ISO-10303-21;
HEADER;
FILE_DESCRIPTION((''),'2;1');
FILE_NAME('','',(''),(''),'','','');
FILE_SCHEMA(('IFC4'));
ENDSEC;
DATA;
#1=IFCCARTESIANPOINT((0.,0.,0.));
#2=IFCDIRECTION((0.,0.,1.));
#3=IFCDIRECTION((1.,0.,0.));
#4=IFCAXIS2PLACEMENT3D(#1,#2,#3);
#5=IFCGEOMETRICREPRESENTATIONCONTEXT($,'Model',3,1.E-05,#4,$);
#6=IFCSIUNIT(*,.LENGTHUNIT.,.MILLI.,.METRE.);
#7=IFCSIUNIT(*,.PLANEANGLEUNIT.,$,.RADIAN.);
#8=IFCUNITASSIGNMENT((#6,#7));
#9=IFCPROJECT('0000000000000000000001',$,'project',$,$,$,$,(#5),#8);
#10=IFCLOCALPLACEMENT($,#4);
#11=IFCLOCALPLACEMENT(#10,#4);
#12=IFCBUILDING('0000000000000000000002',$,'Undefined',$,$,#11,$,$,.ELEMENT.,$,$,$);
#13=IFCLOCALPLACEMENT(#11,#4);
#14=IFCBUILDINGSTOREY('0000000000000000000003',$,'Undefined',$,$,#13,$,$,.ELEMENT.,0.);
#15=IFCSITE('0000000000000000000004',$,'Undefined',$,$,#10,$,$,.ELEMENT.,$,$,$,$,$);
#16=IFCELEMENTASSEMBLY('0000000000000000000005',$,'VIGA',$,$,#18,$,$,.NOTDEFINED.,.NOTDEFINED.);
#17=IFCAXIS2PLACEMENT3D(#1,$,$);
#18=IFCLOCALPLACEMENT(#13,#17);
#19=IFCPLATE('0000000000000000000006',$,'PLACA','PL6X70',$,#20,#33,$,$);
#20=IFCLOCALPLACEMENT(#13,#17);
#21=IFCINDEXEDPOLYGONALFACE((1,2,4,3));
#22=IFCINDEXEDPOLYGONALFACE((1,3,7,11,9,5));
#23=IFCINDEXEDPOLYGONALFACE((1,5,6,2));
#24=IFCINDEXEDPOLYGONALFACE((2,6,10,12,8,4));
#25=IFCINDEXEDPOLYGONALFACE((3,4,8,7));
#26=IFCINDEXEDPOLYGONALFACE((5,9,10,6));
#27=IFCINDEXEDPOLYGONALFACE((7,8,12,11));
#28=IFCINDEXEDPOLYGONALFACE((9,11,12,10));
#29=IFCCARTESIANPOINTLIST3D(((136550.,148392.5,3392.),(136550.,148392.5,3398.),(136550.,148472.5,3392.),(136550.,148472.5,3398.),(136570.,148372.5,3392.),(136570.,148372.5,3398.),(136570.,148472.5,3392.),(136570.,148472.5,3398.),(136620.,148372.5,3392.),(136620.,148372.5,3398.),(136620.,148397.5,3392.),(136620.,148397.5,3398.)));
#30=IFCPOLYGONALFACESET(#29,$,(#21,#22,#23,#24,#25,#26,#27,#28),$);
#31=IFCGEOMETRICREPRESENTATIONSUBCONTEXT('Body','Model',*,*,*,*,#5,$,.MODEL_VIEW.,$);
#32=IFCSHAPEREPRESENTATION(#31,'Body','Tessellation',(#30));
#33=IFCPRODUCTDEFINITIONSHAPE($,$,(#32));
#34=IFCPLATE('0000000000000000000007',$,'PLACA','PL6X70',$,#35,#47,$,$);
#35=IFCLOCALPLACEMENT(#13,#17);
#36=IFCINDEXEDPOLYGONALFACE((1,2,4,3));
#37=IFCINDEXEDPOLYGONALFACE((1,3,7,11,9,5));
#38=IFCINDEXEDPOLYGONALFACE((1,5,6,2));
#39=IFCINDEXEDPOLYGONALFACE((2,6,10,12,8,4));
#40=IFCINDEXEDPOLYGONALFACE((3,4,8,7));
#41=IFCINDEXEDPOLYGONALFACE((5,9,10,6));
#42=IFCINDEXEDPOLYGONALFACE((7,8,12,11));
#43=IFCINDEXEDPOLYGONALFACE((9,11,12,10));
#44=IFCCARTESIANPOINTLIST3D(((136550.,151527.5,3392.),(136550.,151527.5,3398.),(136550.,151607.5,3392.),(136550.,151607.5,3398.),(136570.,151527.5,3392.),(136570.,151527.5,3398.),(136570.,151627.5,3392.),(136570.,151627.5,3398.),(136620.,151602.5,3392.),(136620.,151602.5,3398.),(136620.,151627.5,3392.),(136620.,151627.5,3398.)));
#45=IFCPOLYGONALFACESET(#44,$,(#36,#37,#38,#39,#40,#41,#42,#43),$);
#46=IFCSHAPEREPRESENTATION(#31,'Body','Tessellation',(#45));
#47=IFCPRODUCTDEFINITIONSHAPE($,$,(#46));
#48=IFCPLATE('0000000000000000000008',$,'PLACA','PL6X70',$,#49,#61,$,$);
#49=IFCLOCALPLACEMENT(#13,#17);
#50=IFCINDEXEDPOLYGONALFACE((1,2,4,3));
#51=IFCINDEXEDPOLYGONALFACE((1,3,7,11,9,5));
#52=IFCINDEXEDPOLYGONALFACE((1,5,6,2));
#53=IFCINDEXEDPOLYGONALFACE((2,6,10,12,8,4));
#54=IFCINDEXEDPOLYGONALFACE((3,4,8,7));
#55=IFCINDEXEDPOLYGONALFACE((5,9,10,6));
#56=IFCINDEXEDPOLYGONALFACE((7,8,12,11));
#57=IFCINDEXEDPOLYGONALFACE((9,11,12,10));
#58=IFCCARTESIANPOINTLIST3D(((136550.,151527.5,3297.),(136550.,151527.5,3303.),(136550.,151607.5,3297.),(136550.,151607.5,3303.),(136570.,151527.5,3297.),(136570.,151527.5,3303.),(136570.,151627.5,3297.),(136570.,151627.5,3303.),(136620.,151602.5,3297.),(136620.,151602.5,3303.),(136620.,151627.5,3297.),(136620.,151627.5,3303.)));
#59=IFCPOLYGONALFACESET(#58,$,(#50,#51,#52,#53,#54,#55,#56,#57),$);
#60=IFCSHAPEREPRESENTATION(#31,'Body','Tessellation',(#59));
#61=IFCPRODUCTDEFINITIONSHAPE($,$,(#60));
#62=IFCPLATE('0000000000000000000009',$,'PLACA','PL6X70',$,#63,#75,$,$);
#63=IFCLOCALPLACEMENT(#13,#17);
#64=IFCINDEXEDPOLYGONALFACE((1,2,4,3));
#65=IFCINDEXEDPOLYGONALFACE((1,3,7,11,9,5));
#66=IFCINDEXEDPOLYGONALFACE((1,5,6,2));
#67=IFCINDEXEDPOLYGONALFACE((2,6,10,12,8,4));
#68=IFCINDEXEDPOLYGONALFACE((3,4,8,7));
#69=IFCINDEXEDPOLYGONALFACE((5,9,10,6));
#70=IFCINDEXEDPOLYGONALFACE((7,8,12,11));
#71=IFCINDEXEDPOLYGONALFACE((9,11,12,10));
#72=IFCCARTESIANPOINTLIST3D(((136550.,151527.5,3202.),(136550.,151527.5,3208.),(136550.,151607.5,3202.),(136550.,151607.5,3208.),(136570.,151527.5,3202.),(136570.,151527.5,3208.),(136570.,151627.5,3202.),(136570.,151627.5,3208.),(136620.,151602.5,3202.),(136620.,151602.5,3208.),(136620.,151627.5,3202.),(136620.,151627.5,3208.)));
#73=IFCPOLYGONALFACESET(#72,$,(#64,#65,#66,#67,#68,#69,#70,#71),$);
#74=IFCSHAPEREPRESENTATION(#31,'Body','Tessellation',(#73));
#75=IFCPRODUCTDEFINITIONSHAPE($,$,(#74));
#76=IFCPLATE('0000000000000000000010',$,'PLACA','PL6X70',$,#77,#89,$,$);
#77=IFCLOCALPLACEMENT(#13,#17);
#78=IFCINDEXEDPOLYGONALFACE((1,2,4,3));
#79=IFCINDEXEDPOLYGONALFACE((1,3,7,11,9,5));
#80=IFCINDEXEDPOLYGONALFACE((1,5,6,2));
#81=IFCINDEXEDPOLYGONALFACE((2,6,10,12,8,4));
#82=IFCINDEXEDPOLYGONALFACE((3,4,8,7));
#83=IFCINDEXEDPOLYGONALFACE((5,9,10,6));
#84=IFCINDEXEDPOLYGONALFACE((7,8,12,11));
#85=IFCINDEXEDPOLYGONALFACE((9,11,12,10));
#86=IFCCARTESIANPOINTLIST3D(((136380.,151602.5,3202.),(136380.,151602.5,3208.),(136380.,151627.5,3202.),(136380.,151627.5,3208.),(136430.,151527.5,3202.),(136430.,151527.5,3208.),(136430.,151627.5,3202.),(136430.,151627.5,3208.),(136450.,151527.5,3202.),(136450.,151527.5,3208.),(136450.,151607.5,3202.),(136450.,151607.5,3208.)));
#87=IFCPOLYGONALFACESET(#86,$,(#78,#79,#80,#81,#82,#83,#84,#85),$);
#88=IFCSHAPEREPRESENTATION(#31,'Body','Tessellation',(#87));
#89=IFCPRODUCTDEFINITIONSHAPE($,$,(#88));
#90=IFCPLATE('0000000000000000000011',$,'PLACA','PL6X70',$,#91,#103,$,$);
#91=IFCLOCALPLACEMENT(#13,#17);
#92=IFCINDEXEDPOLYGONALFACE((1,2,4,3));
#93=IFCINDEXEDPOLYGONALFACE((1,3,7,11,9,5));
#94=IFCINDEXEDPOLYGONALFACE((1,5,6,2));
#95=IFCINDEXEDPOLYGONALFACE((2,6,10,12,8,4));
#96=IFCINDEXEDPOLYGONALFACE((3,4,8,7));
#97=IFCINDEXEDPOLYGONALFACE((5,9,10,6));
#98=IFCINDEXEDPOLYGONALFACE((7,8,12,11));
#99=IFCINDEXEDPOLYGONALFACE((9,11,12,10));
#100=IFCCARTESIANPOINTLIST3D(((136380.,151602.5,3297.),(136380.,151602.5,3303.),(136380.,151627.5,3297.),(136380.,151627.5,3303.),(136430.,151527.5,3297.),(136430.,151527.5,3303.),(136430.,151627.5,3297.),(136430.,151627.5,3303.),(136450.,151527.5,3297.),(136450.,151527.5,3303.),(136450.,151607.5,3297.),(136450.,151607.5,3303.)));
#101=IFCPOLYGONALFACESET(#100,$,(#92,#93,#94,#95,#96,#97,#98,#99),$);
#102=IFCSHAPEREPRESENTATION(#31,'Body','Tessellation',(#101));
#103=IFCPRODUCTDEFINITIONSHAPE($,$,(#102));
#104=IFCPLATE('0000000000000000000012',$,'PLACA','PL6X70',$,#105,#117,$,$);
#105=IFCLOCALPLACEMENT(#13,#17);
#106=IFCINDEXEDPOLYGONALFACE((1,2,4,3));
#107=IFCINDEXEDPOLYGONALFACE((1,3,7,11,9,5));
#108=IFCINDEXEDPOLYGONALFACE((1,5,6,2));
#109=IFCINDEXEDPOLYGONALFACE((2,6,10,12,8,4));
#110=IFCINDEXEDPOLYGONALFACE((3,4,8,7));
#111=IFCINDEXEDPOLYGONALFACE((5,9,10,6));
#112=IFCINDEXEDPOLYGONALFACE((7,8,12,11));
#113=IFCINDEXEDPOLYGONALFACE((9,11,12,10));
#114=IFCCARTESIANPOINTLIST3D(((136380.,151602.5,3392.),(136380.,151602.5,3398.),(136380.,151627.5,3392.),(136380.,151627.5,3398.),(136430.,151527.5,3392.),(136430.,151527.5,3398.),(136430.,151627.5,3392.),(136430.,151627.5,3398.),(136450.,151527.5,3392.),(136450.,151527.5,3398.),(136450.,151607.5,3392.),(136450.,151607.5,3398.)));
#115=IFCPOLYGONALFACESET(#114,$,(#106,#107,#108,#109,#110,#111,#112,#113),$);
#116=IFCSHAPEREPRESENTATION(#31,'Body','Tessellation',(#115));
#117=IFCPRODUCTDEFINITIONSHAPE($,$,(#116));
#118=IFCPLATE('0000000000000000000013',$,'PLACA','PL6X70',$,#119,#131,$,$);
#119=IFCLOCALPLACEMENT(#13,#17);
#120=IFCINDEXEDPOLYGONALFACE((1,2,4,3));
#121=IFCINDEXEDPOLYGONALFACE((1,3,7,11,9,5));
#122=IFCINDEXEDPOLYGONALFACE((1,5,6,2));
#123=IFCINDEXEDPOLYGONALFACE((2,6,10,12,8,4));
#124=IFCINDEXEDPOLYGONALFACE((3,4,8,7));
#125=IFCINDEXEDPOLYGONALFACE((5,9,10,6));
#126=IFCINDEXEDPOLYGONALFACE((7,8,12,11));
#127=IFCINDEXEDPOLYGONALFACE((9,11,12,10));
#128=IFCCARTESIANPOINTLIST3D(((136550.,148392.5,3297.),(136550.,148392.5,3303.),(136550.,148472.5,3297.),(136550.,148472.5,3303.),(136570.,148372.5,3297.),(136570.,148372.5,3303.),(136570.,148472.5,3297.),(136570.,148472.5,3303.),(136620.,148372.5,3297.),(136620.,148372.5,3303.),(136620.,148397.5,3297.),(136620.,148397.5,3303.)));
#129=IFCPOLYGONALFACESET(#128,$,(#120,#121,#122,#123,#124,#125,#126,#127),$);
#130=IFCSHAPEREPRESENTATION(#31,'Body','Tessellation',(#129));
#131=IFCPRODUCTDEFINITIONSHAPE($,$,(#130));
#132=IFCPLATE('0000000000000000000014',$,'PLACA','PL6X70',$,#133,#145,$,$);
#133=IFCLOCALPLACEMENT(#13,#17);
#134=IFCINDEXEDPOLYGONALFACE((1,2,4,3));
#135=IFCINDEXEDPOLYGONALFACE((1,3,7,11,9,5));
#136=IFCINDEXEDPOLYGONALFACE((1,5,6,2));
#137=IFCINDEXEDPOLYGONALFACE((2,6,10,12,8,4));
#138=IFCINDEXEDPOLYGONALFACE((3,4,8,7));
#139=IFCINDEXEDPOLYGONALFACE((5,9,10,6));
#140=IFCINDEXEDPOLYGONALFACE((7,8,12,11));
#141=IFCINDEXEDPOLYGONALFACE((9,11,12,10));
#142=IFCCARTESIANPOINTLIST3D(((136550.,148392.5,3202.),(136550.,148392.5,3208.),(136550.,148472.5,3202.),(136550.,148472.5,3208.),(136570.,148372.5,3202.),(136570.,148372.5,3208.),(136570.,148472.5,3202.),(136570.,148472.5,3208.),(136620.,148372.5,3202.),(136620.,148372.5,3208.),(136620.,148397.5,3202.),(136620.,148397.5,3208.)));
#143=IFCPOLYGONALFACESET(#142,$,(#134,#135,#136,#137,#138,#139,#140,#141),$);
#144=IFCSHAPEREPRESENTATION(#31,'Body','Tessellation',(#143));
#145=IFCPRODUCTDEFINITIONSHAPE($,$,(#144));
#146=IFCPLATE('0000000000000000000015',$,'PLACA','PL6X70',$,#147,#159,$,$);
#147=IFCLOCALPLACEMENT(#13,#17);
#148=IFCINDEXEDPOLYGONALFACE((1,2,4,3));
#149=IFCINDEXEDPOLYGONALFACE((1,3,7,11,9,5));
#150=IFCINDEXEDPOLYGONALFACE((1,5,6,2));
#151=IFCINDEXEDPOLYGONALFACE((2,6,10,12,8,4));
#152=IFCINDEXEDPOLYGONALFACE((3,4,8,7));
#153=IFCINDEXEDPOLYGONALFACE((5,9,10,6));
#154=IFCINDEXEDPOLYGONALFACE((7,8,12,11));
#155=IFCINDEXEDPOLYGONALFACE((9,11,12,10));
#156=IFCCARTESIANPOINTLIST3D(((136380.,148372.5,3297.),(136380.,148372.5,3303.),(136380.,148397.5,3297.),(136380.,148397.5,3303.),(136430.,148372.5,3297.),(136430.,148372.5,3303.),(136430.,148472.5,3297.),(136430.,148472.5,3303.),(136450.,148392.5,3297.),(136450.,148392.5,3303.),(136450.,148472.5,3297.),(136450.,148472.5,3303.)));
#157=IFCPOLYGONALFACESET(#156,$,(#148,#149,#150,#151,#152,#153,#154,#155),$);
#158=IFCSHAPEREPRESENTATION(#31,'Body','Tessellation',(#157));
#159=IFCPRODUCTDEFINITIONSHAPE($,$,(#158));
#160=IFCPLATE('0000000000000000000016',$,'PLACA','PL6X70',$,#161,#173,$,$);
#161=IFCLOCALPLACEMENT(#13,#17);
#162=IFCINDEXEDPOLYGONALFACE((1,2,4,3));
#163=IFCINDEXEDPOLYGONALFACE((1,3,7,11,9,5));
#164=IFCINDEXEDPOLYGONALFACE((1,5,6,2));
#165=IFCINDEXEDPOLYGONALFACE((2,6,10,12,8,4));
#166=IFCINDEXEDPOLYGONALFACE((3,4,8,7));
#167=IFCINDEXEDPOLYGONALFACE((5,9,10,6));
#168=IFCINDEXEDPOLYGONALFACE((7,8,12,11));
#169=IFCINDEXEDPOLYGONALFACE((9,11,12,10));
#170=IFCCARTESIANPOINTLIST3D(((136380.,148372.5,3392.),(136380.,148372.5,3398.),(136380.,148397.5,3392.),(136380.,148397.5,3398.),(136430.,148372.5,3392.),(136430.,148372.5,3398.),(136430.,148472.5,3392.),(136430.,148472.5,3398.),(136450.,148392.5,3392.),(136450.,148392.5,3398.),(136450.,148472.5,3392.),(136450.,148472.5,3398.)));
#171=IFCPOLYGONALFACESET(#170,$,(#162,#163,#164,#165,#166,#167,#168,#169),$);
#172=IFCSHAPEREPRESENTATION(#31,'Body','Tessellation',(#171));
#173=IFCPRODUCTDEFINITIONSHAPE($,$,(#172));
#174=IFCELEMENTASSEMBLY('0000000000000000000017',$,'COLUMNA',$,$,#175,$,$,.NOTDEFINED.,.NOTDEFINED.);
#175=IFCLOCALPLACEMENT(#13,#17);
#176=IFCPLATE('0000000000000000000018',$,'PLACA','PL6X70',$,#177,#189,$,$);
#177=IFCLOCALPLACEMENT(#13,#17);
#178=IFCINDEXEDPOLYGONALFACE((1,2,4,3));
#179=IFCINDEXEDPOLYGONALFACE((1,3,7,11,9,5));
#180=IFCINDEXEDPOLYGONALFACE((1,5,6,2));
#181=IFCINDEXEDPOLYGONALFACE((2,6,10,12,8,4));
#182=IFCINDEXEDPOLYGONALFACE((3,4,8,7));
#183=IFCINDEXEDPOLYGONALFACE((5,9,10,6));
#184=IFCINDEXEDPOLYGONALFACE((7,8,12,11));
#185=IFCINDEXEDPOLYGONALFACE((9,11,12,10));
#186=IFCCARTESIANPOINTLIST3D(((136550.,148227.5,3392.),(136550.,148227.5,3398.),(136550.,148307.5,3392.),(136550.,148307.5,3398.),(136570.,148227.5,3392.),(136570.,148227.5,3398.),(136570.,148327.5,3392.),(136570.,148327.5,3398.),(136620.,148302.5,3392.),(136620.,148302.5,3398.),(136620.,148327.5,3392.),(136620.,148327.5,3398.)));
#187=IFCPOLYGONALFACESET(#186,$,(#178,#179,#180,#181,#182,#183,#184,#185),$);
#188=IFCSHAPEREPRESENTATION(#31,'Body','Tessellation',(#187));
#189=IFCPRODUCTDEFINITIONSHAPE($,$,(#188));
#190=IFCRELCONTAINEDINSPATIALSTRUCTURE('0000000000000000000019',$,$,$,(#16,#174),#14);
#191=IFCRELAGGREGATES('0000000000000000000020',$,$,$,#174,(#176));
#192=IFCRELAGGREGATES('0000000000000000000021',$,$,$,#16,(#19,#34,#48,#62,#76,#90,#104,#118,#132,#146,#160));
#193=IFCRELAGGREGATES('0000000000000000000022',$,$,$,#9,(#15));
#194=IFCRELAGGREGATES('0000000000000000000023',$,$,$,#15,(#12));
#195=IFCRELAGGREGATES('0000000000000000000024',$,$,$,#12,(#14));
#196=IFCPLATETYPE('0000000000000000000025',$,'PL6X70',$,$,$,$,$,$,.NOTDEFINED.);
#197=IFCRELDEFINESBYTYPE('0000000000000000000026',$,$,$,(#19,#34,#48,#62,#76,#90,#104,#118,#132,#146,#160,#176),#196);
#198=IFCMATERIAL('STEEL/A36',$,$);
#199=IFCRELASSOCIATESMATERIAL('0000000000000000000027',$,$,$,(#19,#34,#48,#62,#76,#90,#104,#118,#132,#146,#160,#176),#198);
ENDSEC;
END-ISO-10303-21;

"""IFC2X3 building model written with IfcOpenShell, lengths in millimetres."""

from ifc_helpers import new_model, si_unit, frame, origin_with_axes, place, context, subcontext, project, spatial, polyline, outline, extrude, material, type_object, element, aggregate, save


model = new_model("IFC2X3")

# Units and contexts
model_context = context("Model", 3, precision=1e-05, world=origin_with_axes())
body_context = subcontext(model_context, "Body", "Model", "MODEL_VIEW")
ifc_project = project(units=[si_unit("LENGTHUNIT", "METRE", prefix="MILLI"), si_unit("PLANEANGLEUNIT", "RADIAN")], contexts=[model_context])

# Site, building, storey
site_placement = place(None, origin_with_axes())
site = spatial("IfcSite", under=ifc_project, at=site_placement, Name="Undefined", CompositionType="ELEMENT")
building_placement = place(site_placement, origin_with_axes())
building = spatial("IfcBuilding", under=site, at=building_placement, Name="Undefined", CompositionType="ELEMENT")
storey_placement = place(building_placement, origin_with_axes())
storey = spatial("IfcBuildingStorey", under=building, at=storey_placement, Name="Undefined", CompositionType="ELEMENT", Elevation=0.0)

# Element assembly
assembly_1_placement = place(storey_placement, origin_with_axes())
assembly_1 = element("IfcElementAssembly", 1, at=assembly_1_placement, inside=storey, Name="VIGA", AssemblyPlace="NOTDEFINED", PredefinedType="NOTDEFINED")
ifc_material_1 = material(Name="STEEL/A36")

# Plates
plate_type_1 = type_object("IfcPlateType", Name="PL6X70", PredefinedType="NOTDEFINED")
plate_1_placement = place(assembly_1_placement, frame((136620.0, 148372.5, 3395.0), z_axis=(0.0, 0.0, 1.0), x_axis=(0.0, 1.0, 0.0)))
plate_1 = element("IfcPlate", 2, at=plate_1_placement, type_object=plate_type_1, material=ifc_material_1, Name="PLACA", Description="PL6X70", context=body_context, shape_type="SweptSolid", body=[
    extrude(outline(polyline([(0.0, 0.0), (25.0, 0.0), (100.0, 50.0), (100.0, 70.0), (20.0, 70.0), (0.0, 50.0), (0.0, 0.0)])), frame((0.0, 0.0, -3.0), z_axis=(0.0, 0.0, 1.0), x_axis=(1.0, 0.0, 0.0)), (0.0, 0.0, 1.0), 6.0),
])
plate_2_placement = place(assembly_1_placement, frame((136620.0, 151627.5, 3395.0), z_axis=(0.0, 0.0, -1.0), x_axis=(0.0, -1.0, 0.0)))
plate_2 = element("IfcPlate", 3, at=plate_2_placement, type_object=plate_type_1, material=ifc_material_1, Name="PLACA", Description="PL6X70", context=body_context, shape_type="SweptSolid", body=[
    extrude(outline(polyline([(0.0, 0.0), (25.0, 0.0), (100.0, 50.0), (100.0, 70.0), (20.0, 70.0), (0.0, 50.0), (0.0, 0.0)])), frame((0.0, 0.0, -3.0), z_axis=(0.0, 0.0, 1.0), x_axis=(1.0, 0.0, 0.0)), (0.0, 0.0, 1.0), 6.0),
])
plate_3_placement = place(assembly_1_placement, frame((136620.0, 151627.5, 3300.0), z_axis=(0.0, 0.0, -1.0), x_axis=(0.0, -1.0, 0.0)))
plate_3 = element("IfcPlate", 4, at=plate_3_placement, type_object=plate_type_1, material=ifc_material_1, Name="PLACA", Description="PL6X70", context=body_context, shape_type="SweptSolid", body=[
    extrude(outline(polyline([(0.0, 0.0), (25.0, 0.0), (100.0, 50.0), (100.0, 70.0), (20.0, 70.0), (0.0, 50.0), (0.0, 0.0)])), frame((0.0, 0.0, -3.0), z_axis=(0.0, 0.0, 1.0), x_axis=(1.0, 0.0, 0.0)), (0.0, 0.0, 1.0), 6.0),
])
plate_4_placement = place(assembly_1_placement, frame((136620.0, 151627.5, 3205.0), z_axis=(0.0, 0.0, -1.0), x_axis=(0.0, -1.0, 0.0)))
plate_4 = element("IfcPlate", 5, at=plate_4_placement, type_object=plate_type_1, material=ifc_material_1, Name="PLACA", Description="PL6X70", context=body_context, shape_type="SweptSolid", body=[
    extrude(outline(polyline([(0.0, 0.0), (25.0, 0.0), (100.0, 50.0), (100.0, 70.0), (20.0, 70.0), (0.0, 50.0), (0.0, 0.0)])), frame((0.0, 0.0, -3.0), z_axis=(0.0, 0.0, 1.0), x_axis=(1.0, 0.0, 0.0)), (0.0, 0.0, 1.0), 6.0),
])
plate_5_placement = place(assembly_1_placement, frame((136380.0, 151627.5, 3205.0), z_axis=(0.0, 0.0, 1.0), x_axis=(0.0, -1.0, 0.0)))
plate_5 = element("IfcPlate", 6, at=plate_5_placement, type_object=plate_type_1, material=ifc_material_1, Name="PLACA", Description="PL6X70", context=body_context, shape_type="SweptSolid", body=[
    extrude(outline(polyline([(0.0, 0.0), (25.0, 0.0), (100.0, 50.0), (100.0, 70.0), (20.0, 70.0), (0.0, 50.0), (0.0, 0.0)])), frame((0.0, 0.0, -3.0), z_axis=(0.0, 0.0, 1.0), x_axis=(1.0, 0.0, 0.0)), (0.0, 0.0, 1.0), 6.0),
])
plate_6_placement = place(assembly_1_placement, frame((136380.0, 151627.5, 3300.0), z_axis=(0.0, 0.0, 1.0), x_axis=(0.0, -1.0, 0.0)))
plate_6 = element("IfcPlate", 7, at=plate_6_placement, type_object=plate_type_1, material=ifc_material_1, Name="PLACA", Description="PL6X70", context=body_context, shape_type="SweptSolid", body=[
    extrude(outline(polyline([(0.0, 0.0), (25.0, 0.0), (100.0, 50.0), (100.0, 70.0), (20.0, 70.0), (0.0, 50.0), (0.0, 0.0)])), frame((0.0, 0.0, -3.0), z_axis=(0.0, 0.0, 1.0), x_axis=(1.0, 0.0, 0.0)), (0.0, 0.0, 1.0), 6.0),
])
plate_7_placement = place(assembly_1_placement, frame((136380.0, 151627.5, 3395.0), z_axis=(0.0, 0.0, 1.0), x_axis=(0.0, -1.0, 0.0)))
plate_7 = element("IfcPlate", 8, at=plate_7_placement, type_object=plate_type_1, material=ifc_material_1, Name="PLACA", Description="PL6X70", context=body_context, shape_type="SweptSolid", body=[
    extrude(outline(polyline([(0.0, 0.0), (25.0, 0.0), (100.0, 50.0), (100.0, 70.0), (20.0, 70.0), (0.0, 50.0), (0.0, 0.0)])), frame((0.0, 0.0, -3.0), z_axis=(0.0, 0.0, 1.0), x_axis=(1.0, 0.0, 0.0)), (0.0, 0.0, 1.0), 6.0),
])
plate_8_placement = place(assembly_1_placement, frame((136620.0, 148372.5, 3300.0), z_axis=(0.0, 0.0, 1.0), x_axis=(0.0, 1.0, 0.0)))
plate_8 = element("IfcPlate", 9, at=plate_8_placement, type_object=plate_type_1, material=ifc_material_1, Name="PLACA", Description="PL6X70", context=body_context, shape_type="SweptSolid", body=[
    extrude(outline(polyline([(0.0, 0.0), (25.0, 0.0), (100.0, 50.0), (100.0, 70.0), (20.0, 70.0), (0.0, 50.0), (0.0, 0.0)])), frame((0.0, 0.0, -3.0), z_axis=(0.0, 0.0, 1.0), x_axis=(1.0, 0.0, 0.0)), (0.0, 0.0, 1.0), 6.0),
])
plate_9_placement = place(assembly_1_placement, frame((136620.0, 148372.5, 3205.0), z_axis=(0.0, 0.0, 1.0), x_axis=(0.0, 1.0, 0.0)))
plate_9 = element("IfcPlate", 10, at=plate_9_placement, type_object=plate_type_1, material=ifc_material_1, Name="PLACA", Description="PL6X70", context=body_context, shape_type="SweptSolid", body=[
    extrude(outline(polyline([(0.0, 0.0), (25.0, 0.0), (100.0, 50.0), (100.0, 70.0), (20.0, 70.0), (0.0, 50.0), (0.0, 0.0)])), frame((0.0, 0.0, -3.0), z_axis=(0.0, 0.0, 1.0), x_axis=(1.0, 0.0, 0.0)), (0.0, 0.0, 1.0), 6.0),
])
plate_10_placement = place(assembly_1_placement, frame((136380.0, 148372.5, 3300.0), z_axis=(0.0, 0.0, -1.0), x_axis=(0.0, 1.0, 0.0)))
plate_10 = element("IfcPlate", 11, at=plate_10_placement, type_object=plate_type_1, material=ifc_material_1, Name="PLACA", Description="PL6X70", context=body_context, shape_type="SweptSolid", body=[
    extrude(outline(polyline([(0.0, 0.0), (25.0, 0.0), (100.0, 50.0), (100.0, 70.0), (20.0, 70.0), (0.0, 50.0), (0.0, 0.0)])), frame((0.0, 0.0, -3.0), z_axis=(0.0, 0.0, 1.0), x_axis=(1.0, 0.0, 0.0)), (0.0, 0.0, 1.0), 6.0),
])
plate_11_placement = place(assembly_1_placement, frame((136380.0, 148372.5, 3395.0), z_axis=(0.0, 0.0, -1.0), x_axis=(0.0, 1.0, 0.0)))
plate_11 = element("IfcPlate", 12, at=plate_11_placement, type_object=plate_type_1, material=ifc_material_1, Name="PLACA", Description="PL6X70", context=body_context, shape_type="SweptSolid", body=[
    extrude(outline(polyline([(0.0, 0.0), (25.0, 0.0), (100.0, 50.0), (100.0, 70.0), (20.0, 70.0), (0.0, 50.0), (0.0, 0.0)])), frame((0.0, 0.0, -3.0), z_axis=(0.0, 0.0, 1.0), x_axis=(1.0, 0.0, 0.0)), (0.0, 0.0, 1.0), 6.0),
])

# Element assembly, plate
assembly_2_placement = place(storey_placement, origin_with_axes())
assembly_2 = element("IfcElementAssembly", 13, at=assembly_2_placement, inside=storey, Name="COLUMNA", AssemblyPlace="NOTDEFINED", PredefinedType="NOTDEFINED")
plate_12_placement = place(assembly_2_placement, frame((136620.0, 148327.5, 3395.0), z_axis=(0.0, 0.0, -1.0), x_axis=(0.0, -1.0, 0.0)))
plate_12 = element("IfcPlate", 14, at=plate_12_placement, type_object=plate_type_1, material=ifc_material_1, Name="PLACA", Description="PL6X70", context=body_context, shape_type="SweptSolid", body=[
    extrude(outline(polyline([(0.0, 0.0), (25.0, 0.0), (100.0, 50.0), (100.0, 70.0), (20.0, 70.0), (0.0, 50.0), (0.0, 0.0)])), frame((0.0, 0.0, -3.0), z_axis=(0.0, 0.0, 1.0), x_axis=(1.0, 0.0, 0.0)), (0.0, 0.0, 1.0), 6.0),
])

aggregate(assembly_2, [plate_12])

aggregate(assembly_1, [plate_1, plate_2, plate_3, plate_4, plate_5, plate_6, plate_7, plate_8, plate_9, plate_10, plate_11])

save(model, "model.ifc")
